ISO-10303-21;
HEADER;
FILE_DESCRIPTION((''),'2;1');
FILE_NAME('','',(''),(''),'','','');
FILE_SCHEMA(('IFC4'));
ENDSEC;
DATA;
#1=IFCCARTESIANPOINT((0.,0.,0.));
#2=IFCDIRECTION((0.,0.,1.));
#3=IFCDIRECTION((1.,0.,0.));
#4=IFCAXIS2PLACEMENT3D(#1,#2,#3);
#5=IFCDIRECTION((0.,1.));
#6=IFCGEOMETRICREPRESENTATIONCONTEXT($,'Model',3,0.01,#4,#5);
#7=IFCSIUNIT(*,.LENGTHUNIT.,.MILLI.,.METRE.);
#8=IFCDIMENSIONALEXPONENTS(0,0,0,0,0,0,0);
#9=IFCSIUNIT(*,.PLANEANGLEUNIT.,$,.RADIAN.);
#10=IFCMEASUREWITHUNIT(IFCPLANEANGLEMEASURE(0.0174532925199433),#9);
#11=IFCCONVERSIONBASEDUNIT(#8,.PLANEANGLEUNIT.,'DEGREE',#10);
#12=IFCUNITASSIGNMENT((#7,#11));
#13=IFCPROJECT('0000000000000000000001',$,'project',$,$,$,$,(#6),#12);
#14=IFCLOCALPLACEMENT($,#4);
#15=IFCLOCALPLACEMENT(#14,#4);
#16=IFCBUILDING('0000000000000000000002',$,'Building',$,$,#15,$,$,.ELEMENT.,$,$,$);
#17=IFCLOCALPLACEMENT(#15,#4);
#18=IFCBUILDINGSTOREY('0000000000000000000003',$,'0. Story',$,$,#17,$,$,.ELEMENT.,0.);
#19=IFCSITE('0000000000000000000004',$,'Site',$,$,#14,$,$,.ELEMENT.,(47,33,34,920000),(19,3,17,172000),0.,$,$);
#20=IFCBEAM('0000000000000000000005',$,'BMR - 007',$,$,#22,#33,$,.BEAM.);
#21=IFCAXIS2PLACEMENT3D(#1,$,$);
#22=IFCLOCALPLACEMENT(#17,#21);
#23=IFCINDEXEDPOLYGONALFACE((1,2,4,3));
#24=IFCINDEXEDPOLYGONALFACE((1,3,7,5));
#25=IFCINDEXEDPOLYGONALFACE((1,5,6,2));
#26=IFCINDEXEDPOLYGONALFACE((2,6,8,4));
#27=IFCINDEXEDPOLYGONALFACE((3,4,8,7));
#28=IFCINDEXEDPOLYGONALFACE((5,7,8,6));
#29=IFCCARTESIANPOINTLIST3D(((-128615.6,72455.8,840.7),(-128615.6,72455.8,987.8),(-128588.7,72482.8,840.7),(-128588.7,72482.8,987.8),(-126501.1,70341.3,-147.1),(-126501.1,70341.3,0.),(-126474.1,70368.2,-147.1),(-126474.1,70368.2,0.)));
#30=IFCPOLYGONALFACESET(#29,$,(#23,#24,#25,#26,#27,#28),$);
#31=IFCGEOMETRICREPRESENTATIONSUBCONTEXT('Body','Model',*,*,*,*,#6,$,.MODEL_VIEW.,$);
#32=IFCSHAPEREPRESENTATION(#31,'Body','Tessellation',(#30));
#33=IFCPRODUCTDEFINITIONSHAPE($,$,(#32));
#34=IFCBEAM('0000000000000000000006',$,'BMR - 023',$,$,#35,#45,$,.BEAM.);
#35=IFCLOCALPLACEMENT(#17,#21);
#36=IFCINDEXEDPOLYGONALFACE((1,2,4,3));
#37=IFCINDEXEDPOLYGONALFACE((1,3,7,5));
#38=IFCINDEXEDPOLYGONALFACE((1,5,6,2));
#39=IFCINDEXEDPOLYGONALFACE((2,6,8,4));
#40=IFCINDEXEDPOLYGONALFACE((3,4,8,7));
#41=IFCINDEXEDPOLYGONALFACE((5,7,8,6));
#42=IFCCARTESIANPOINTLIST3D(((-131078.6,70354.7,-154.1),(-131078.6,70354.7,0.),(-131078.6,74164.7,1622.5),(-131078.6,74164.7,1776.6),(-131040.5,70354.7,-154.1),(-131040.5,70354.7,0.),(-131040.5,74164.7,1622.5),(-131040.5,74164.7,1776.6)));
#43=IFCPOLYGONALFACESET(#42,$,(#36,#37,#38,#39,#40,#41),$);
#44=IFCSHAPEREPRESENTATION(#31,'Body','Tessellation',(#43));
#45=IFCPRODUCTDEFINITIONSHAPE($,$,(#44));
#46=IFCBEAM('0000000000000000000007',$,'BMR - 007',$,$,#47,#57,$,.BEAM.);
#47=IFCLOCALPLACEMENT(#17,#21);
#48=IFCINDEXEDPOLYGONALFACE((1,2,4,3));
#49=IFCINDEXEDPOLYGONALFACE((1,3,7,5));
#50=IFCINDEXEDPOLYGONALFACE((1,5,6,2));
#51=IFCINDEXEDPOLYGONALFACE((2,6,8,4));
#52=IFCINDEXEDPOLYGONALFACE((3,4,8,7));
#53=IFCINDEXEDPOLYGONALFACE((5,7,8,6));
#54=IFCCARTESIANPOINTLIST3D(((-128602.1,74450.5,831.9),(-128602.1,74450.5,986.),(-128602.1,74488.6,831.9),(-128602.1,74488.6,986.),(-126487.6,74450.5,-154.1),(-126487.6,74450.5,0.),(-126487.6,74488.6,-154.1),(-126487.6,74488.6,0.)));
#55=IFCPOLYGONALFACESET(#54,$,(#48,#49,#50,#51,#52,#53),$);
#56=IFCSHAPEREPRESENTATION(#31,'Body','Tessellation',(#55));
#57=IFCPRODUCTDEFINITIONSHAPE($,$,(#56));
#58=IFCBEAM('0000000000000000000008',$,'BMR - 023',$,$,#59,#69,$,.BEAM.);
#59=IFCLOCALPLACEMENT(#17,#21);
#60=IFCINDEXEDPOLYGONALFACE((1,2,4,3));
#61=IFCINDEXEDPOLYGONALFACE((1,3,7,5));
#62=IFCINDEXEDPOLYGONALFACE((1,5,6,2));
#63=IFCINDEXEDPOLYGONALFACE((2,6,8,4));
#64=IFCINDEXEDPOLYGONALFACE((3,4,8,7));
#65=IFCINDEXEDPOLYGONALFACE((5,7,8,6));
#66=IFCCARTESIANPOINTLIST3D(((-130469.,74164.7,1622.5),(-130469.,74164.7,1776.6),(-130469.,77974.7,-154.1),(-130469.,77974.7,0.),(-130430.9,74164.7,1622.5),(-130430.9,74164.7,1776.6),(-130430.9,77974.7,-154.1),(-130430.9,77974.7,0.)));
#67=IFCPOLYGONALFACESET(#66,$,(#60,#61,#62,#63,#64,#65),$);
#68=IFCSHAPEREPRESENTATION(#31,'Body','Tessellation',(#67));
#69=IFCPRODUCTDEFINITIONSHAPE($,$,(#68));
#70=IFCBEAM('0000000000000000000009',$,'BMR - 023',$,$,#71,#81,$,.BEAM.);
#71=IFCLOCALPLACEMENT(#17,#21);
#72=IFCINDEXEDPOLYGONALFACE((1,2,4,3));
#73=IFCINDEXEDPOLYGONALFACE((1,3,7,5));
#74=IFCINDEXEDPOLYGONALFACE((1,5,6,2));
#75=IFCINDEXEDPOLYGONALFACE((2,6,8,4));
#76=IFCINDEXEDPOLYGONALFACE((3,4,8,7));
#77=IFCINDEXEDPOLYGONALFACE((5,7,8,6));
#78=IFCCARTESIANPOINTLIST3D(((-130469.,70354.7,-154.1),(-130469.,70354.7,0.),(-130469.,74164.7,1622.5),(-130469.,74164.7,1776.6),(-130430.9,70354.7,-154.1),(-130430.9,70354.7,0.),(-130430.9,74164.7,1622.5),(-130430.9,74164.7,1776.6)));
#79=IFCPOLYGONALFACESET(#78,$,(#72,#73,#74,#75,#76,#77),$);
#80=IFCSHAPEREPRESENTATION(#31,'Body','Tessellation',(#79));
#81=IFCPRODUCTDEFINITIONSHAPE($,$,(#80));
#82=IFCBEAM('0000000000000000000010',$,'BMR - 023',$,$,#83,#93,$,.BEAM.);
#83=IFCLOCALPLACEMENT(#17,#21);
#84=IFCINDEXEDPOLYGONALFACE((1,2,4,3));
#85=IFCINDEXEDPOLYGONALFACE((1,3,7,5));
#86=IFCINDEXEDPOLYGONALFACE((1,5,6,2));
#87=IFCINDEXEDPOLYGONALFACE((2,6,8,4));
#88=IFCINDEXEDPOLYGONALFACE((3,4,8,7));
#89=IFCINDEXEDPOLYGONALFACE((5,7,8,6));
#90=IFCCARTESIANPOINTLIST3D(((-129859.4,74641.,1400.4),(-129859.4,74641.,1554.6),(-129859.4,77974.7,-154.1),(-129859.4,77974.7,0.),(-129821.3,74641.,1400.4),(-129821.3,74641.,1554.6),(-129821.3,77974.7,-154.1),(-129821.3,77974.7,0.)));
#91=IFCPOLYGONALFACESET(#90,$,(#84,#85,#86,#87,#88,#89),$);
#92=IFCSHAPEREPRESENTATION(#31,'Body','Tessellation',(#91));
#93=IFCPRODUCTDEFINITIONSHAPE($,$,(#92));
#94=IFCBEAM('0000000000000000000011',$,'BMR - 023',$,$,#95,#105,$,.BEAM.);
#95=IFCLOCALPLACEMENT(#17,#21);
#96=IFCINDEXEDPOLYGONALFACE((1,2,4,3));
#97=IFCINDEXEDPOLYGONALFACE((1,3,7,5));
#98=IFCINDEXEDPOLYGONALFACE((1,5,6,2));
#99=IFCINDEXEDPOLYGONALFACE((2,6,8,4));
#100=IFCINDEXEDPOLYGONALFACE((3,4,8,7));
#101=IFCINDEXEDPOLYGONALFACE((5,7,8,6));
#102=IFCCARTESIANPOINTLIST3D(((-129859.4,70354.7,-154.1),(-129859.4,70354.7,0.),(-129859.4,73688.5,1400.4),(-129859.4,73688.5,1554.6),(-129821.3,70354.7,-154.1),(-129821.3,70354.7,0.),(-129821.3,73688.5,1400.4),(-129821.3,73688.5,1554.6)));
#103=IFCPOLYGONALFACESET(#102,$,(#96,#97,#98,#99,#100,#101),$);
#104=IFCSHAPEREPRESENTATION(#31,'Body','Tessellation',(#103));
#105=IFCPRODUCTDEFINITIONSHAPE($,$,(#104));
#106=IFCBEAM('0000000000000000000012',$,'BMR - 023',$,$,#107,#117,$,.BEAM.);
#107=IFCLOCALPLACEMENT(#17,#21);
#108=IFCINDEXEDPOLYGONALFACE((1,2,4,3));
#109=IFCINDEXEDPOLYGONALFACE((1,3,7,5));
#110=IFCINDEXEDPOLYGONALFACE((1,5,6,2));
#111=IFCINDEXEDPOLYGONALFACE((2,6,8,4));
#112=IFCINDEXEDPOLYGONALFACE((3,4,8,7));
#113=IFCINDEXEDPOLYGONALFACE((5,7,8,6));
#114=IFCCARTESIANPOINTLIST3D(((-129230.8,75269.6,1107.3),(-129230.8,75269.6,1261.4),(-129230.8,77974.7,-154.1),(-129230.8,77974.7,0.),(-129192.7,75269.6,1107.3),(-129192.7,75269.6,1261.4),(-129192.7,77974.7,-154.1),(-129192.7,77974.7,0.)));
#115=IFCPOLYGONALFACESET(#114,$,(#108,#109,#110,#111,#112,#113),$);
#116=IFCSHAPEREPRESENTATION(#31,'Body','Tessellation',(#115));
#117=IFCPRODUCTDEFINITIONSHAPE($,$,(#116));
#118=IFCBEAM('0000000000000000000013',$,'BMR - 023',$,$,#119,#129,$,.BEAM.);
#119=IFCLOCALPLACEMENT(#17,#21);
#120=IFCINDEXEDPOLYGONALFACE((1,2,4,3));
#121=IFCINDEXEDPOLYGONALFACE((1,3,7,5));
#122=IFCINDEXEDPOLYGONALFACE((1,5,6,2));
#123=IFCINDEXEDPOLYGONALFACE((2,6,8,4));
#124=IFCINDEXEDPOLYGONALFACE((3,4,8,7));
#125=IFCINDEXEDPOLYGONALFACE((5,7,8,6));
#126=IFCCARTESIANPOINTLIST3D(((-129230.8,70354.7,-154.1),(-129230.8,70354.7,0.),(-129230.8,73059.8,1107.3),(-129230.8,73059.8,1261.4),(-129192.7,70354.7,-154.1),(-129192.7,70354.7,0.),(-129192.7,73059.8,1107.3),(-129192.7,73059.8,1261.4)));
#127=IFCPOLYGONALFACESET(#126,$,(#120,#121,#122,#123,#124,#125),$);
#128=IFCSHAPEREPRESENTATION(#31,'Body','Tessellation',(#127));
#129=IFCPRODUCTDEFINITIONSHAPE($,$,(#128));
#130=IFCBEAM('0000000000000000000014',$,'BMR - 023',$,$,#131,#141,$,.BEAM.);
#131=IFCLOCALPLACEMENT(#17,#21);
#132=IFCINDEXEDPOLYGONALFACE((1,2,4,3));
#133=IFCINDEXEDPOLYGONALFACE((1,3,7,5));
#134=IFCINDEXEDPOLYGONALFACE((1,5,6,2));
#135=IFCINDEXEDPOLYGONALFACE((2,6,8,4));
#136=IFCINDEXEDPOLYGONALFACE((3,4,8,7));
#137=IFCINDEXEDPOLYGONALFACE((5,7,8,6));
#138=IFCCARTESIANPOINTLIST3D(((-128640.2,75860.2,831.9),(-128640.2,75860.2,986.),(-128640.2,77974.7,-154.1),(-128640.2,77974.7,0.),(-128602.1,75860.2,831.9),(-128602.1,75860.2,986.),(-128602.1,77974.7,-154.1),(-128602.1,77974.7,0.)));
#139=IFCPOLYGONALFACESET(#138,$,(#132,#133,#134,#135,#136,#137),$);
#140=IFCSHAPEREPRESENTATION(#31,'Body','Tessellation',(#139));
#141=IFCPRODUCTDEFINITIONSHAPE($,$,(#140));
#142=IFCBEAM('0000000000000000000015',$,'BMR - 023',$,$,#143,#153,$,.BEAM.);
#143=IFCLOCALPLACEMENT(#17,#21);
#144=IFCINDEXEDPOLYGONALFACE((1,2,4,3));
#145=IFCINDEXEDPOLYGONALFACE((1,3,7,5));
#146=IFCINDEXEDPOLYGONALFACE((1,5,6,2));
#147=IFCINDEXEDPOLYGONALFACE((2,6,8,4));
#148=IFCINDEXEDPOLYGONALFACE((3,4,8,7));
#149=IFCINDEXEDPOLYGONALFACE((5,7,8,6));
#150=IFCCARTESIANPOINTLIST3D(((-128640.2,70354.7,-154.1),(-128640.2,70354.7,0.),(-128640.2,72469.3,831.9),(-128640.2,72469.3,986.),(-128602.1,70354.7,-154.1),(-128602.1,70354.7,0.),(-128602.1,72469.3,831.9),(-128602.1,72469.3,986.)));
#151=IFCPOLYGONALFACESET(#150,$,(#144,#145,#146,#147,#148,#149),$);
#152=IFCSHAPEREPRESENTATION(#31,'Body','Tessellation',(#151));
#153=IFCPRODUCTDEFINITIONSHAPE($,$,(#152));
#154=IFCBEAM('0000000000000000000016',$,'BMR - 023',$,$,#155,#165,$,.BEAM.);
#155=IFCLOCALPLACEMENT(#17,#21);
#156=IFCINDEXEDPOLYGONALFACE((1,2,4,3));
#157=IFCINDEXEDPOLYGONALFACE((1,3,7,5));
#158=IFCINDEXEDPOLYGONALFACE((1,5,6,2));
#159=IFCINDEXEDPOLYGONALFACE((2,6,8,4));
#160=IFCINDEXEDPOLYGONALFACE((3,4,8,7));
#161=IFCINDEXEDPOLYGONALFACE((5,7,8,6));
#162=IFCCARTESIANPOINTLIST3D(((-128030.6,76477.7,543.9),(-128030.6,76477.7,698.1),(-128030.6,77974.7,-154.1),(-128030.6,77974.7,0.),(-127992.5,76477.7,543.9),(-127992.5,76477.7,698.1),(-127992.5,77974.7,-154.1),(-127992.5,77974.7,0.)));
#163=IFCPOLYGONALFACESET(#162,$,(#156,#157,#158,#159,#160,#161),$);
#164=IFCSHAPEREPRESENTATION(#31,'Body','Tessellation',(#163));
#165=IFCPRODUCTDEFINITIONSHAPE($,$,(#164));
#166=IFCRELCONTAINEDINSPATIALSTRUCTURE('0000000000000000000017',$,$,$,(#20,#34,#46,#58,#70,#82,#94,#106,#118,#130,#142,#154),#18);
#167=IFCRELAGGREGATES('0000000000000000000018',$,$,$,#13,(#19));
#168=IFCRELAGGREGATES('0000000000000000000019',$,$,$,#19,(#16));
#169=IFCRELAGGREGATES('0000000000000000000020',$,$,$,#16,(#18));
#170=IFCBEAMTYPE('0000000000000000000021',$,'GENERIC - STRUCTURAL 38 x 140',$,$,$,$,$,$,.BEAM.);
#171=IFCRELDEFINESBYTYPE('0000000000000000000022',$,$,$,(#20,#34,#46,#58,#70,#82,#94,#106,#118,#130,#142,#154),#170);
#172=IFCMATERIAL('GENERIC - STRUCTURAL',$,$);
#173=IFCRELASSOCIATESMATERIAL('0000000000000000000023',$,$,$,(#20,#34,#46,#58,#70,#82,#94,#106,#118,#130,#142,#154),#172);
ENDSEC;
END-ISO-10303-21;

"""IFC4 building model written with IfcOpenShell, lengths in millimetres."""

from ifc_helpers import new_model, entity, si_unit, converted_unit, direction, frame, frame_2d, origin_with_axes, place, context, subcontext, project, spatial, rectangle, extrude, clip, halfspace, material, type_object, element, save


model = new_model("IFC4")

# Units and contexts
model_context = context("Model", 3, precision=0.01, world=origin_with_axes(), true_north=direction((0.0, 1.0)))
body_context = subcontext(model_context, "Body", "Model", "MODEL_VIEW")
ifc_project = project(units=[si_unit("LENGTHUNIT", "METRE", prefix="MILLI"), converted_unit("PLANEANGLEUNIT", "DEGREE", entity("IfcPlaneAngleMeasure", 0.0174532925199433), si_unit("PLANEANGLEUNIT", "RADIAN"), dimensions=[0, 0, 0, 0, 0, 0, 0])], contexts=[model_context])

# Site, building, storey
site_placement = place(None, origin_with_axes())
site = spatial("IfcSite", under=ifc_project, at=site_placement, Name="Site", CompositionType="ELEMENT", RefLatitude=(47, 33, 34, 920000), RefLongitude=(19, 3, 17, 172000), RefElevation=0.0)
building_placement = place(site_placement, origin_with_axes())
building = spatial("IfcBuilding", under=site, at=building_placement, Name="Building", CompositionType="ELEMENT")
storey_placement = place(building_placement, origin_with_axes())
storey = spatial("IfcBuildingStorey", under=building, at=storey_placement, Name="0. Story", CompositionType="ELEMENT", Elevation=0.0)

# Beams
ifc_material = material(Name="GENERIC - STRUCTURAL")
beam_type = type_object("IfcBeamType", Name="GENERIC - STRUCTURAL 38 x 140", PredefinedType="BEAM")
beam_1_placement = place(storey_placement, frame((-126487.6, 70354.7, 0.0), z_axis=(0.0, 0.0, 1.0), x_axis=(0.707107, 0.707107, 0.0)))
element("IfcBeam", 1, at=beam_1_placement, inside=storey, type_object=beam_type, material=ifc_material, Name="BMR - 007", PredefinedType="BEAM", context=body_context, shape_type="Clipping", body=[
    clip(clip(extrude(rectangle(XDim=139.7, YDim=38.1, at=frame_2d((-69.8, 0.0), x_axis=(1.0, 0.0))), frame((0.0, -62.0, -20.5), z_axis=(0.0, 0.94954, 0.313647), x_axis=(0.0, -0.313647, 0.94954)), (0.0, 0.0, 1.0), 3279.9), halfspace(frame((0.0, 0.0, 0.0), z_axis=(0.0, 1.0, 0.0), x_axis=(0.0, 0.0, 1.0)), True)), halfspace(frame((0.0, 2990.4, 0.0), z_axis=(0.0, -1.0, 0.0), x_axis=(0.0, 0.0, -1.0)), True)),
])
beam_2_placement = place(storey_placement, frame((-131059.6, 70354.7, 0.0), z_axis=(0.0, 0.0, 1.0), x_axis=(1.0, 0.0, 0.0)))
element("IfcBeam", 2, at=beam_2_placement, inside=storey, type_object=beam_type, material=ifc_material, Name="BMR - 023", PredefinedType="BEAM", context=body_context, shape_type="Clipping", body=[
    clip(clip(extrude(rectangle(XDim=139.7, YDim=38.1, at=frame_2d((-69.8, 0.0), x_axis=(1.0, 0.0))), frame((0.0, -83.5, -38.9), z_axis=(0.0, 0.906308, 0.422618), x_axis=(0.0, -0.422618, 0.906308)), (0.0, 0.0, 1.0), 4388.1), halfspace(frame((0.0, 0.0, 0.0), z_axis=(0.0, 1.0, 0.0), x_axis=(0.0, 0.0, 1.0)), True)), halfspace(frame((0.0, 3810.0, 0.0), z_axis=(0.0, -1.0, 0.0), x_axis=(0.0, 0.0, -1.0)), True)),
])
beam_3_placement = place(storey_placement, frame((-126487.6, 74469.5, 0.0), z_axis=(0.0, 0.0, 1.0), x_axis=(0.0, 1.0, 0.0)))
element("IfcBeam", 3, at=beam_3_placement, inside=storey, type_object=beam_type, material=ifc_material, Name="BMR - 007", PredefinedType="BEAM", context=body_context, shape_type="Clipping", body=[
    clip(clip(extrude(rectangle(XDim=139.7, YDim=38.1, at=frame_2d((-69.8, 0.0), x_axis=(1.0, 0.0))), frame((0.0, -83.5, -38.9), z_axis=(0.0, 0.906308, 0.422618), x_axis=(0.0, -0.422618, 0.906308)), (0.0, 0.0, 1.0), 2517.4), halfspace(frame((0.0, 0.0, 0.0), z_axis=(0.0, 1.0, 0.0), x_axis=(0.0, 0.0, 1.0)), True)), halfspace(frame((0.0, 2114.5, 0.0), z_axis=(0.0, -1.0, 0.0), x_axis=(0.0, 0.0, -1.0)), True)),
])
beam_4_placement = place(storey_placement, frame((-130450.0, 77974.7, 0.0), z_axis=(0.0, 0.0, 1.0), x_axis=(-1.0, 0.0, 0.0)))
element("IfcBeam", 4, at=beam_4_placement, inside=storey, type_object=beam_type, material=ifc_material, Name="BMR - 023", PredefinedType="BEAM", context=body_context, shape_type="Clipping", body=[
    clip(clip(extrude(rectangle(XDim=139.7, YDim=38.1, at=frame_2d((-69.8, 0.0), x_axis=(1.0, 0.0))), frame((0.0, -83.5, -38.9), z_axis=(0.0, 0.906308, 0.422618), x_axis=(0.0, -0.422618, 0.906308)), (0.0, 0.0, 1.0), 4388.1), halfspace(frame((0.0, 0.0, 0.0), z_axis=(0.0, 1.0, 0.0), x_axis=(0.0, 0.0, 1.0)), True)), halfspace(frame((0.0, 3810.0, 0.0), z_axis=(0.0, -1.0, 0.0), x_axis=(0.0, 0.0, -1.0)), True)),
])
beam_5_placement = place(storey_placement, frame((-130450.0, 70354.7, 0.0), z_axis=(0.0, 0.0, 1.0), x_axis=(1.0, 0.0, 0.0)))
element("IfcBeam", 5, at=beam_5_placement, inside=storey, type_object=beam_type, material=ifc_material, Name="BMR - 023", PredefinedType="BEAM", context=body_context, shape_type="Clipping", body=[
    clip(clip(extrude(rectangle(XDim=139.7, YDim=38.1, at=frame_2d((-69.8, 0.0), x_axis=(1.0, 0.0))), frame((0.0, -83.5, -38.9), z_axis=(0.0, 0.906308, 0.422618), x_axis=(0.0, -0.422618, 0.906308)), (0.0, 0.0, 1.0), 4388.1), halfspace(frame((0.0, 0.0, 0.0), z_axis=(0.0, 1.0, 0.0), x_axis=(0.0, 0.0, 1.0)), True)), halfspace(frame((0.0, 3810.0, 0.0), z_axis=(0.0, -1.0, 0.0), x_axis=(0.0, 0.0, -1.0)), True)),
])
beam_6_placement = place(storey_placement, frame((-129840.4, 77974.7, 0.0), z_axis=(0.0, 0.0, 1.0), x_axis=(-1.0, 0.0, 0.0)))
element("IfcBeam", 6, at=beam_6_placement, inside=storey, type_object=beam_type, material=ifc_material, Name="BMR - 023", PredefinedType="BEAM", context=body_context, shape_type="Clipping", body=[
    clip(clip(extrude(rectangle(XDim=139.7, YDim=38.1, at=frame_2d((-69.8, 0.0), x_axis=(1.0, 0.0))), frame((0.0, -83.5, -38.9), z_axis=(0.0, 0.906308, 0.422618), x_axis=(0.0, -0.422618, 0.906308)), (0.0, 0.0, 1.0), 3862.6), halfspace(frame((0.0, 0.0, 0.0), z_axis=(0.0, 1.0, 0.0), x_axis=(0.0, 0.0, 1.0)), True)), halfspace(frame((0.0, 3333.8, 0.0), z_axis=(0.0, -1.0, 0.0), x_axis=(0.0, 0.0, -1.0)), True)),
])
beam_7_placement = place(storey_placement, frame((-129840.4, 70354.7, 0.0), z_axis=(0.0, 0.0, 1.0), x_axis=(1.0, 0.0, 0.0)))
element("IfcBeam", 7, at=beam_7_placement, inside=storey, type_object=beam_type, material=ifc_material, Name="BMR - 023", PredefinedType="BEAM", context=body_context, shape_type="Clipping", body=[
    clip(clip(extrude(rectangle(XDim=139.7, YDim=38.1, at=frame_2d((-69.8, 0.0), x_axis=(1.0, 0.0))), frame((0.0, -83.5, -38.9), z_axis=(0.0, 0.906308, 0.422618), x_axis=(0.0, -0.422618, 0.906308)), (0.0, 0.0, 1.0), 3862.6), halfspace(frame((0.0, 0.0, 0.0), z_axis=(0.0, 1.0, 0.0), x_axis=(0.0, 0.0, 1.0)), True)), halfspace(frame((0.0, 3333.7, 0.0), z_axis=(0.0, -1.0, 0.0), x_axis=(0.0, 0.0, -1.0)), True)),
])
beam_8_placement = place(storey_placement, frame((-129211.7, 77974.7, 0.0), z_axis=(0.0, 0.0, 1.0), x_axis=(-1.0, 0.0, 0.0)))
element("IfcBeam", 8, at=beam_8_placement, inside=storey, type_object=beam_type, material=ifc_material, Name="BMR - 023", PredefinedType="BEAM", context=body_context, shape_type="Clipping", body=[
    clip(clip(extrude(rectangle(XDim=139.7, YDim=38.1, at=frame_2d((-69.8, 0.0), x_axis=(1.0, 0.0))), frame((0.0, -83.5, -38.9), z_axis=(0.0, 0.906308, 0.422618), x_axis=(0.0, -0.422618, 0.906308)), (0.0, 0.0, 1.0), 3169.0), halfspace(frame((0.0, 0.0, 0.0), z_axis=(0.0, 1.0, 0.0), x_axis=(0.0, 0.0, 1.0)), True)), halfspace(frame((0.0, 2705.1, 0.0), z_axis=(0.0, -1.0, 0.0), x_axis=(0.0, 0.0, -1.0)), True)),
])
beam_9_placement = place(storey_placement, frame((-129211.7, 70354.7, 0.0), z_axis=(0.0, 0.0, 1.0), x_axis=(1.0, 0.0, 0.0)))
element("IfcBeam", 9, at=beam_9_placement, inside=storey, type_object=beam_type, material=ifc_material, Name="BMR - 023", PredefinedType="BEAM", context=body_context, shape_type="Clipping", body=[
    clip(clip(extrude(rectangle(XDim=139.7, YDim=38.1, at=frame_2d((-69.8, 0.0), x_axis=(1.0, 0.0))), frame((0.0, -83.5, -38.9), z_axis=(0.0, 0.906308, 0.422618), x_axis=(0.0, -0.422618, 0.906308)), (0.0, 0.0, 1.0), 3169.0), halfspace(frame((0.0, 0.0, 0.0), z_axis=(0.0, 1.0, 0.0), x_axis=(0.0, 0.0, 1.0)), True)), halfspace(frame((0.0, 2705.1, 0.0), z_axis=(0.0, -1.0, 0.0), x_axis=(0.0, 0.0, -1.0)), True)),
])
beam_10_placement = place(storey_placement, frame((-128621.2, 77974.7, 0.0), z_axis=(0.0, 0.0, 1.0), x_axis=(-1.0, 0.0, 0.0)))
element("IfcBeam", 10, at=beam_10_placement, inside=storey, type_object=beam_type, material=ifc_material, Name="BMR - 023", PredefinedType="BEAM", context=body_context, shape_type="Clipping", body=[
    clip(clip(extrude(rectangle(XDim=139.7, YDim=38.1, at=frame_2d((-69.8, 0.0), x_axis=(1.0, 0.0))), frame((0.0, -83.5, -38.9), z_axis=(0.0, 0.906308, 0.422618), x_axis=(0.0, -0.422618, 0.906308)), (0.0, 0.0, 1.0), 2517.4), halfspace(frame((0.0, 0.0, 0.0), z_axis=(0.0, 1.0, 0.0), x_axis=(0.0, 0.0, 1.0)), True)), halfspace(frame((0.0, 2114.6, 0.0), z_axis=(0.0, -1.0, 0.0), x_axis=(0.0, 0.0, -1.0)), True)),
])
beam_11_placement = place(storey_placement, frame((-128621.2, 70354.7, 0.0), z_axis=(0.0, 0.0, 1.0), x_axis=(1.0, 0.0, 0.0)))
element("IfcBeam", 11, at=beam_11_placement, inside=storey, type_object=beam_type, material=ifc_material, Name="BMR - 023", PredefinedType="BEAM", context=body_context, shape_type="Clipping", body=[
    clip(clip(extrude(rectangle(XDim=139.7, YDim=38.1, at=frame_2d((-69.8, 0.0), x_axis=(1.0, 0.0))), frame((0.0, -83.5, -38.9), z_axis=(0.0, 0.906308, 0.422618), x_axis=(0.0, -0.422618, 0.906308)), (0.0, 0.0, 1.0), 2517.4), halfspace(frame((0.0, 0.0, 0.0), z_axis=(0.0, 1.0, 0.0), x_axis=(0.0, 0.0, 1.0)), True)), halfspace(frame((0.0, 2114.5, 0.0), z_axis=(0.0, -1.0, 0.0), x_axis=(0.0, 0.0, -1.0)), True)),
])
beam_12_placement = place(storey_placement, frame((-128011.6, 77974.7, 0.0), z_axis=(0.0, 0.0, 1.0), x_axis=(-1.0, 0.0, 0.0)))
element("IfcBeam", 12, at=beam_12_placement, inside=storey, type_object=beam_type, material=ifc_material, Name="BMR - 023", PredefinedType="BEAM", context=body_context, shape_type="Clipping", body=[
    clip(clip(extrude(rectangle(XDim=139.7, YDim=38.1, at=frame_2d((-69.8, 0.0), x_axis=(1.0, 0.0))), frame((0.0, -83.5, -38.9), z_axis=(0.0, 0.906308, 0.422618), x_axis=(0.0, -0.422618, 0.906308)), (0.0, 0.0, 1.0), 1836.1), halfspace(frame((0.0, 0.0, 0.0), z_axis=(0.0, 1.0, 0.0), x_axis=(0.0, 0.0, 1.0)), True)), halfspace(frame((0.0, 1497.1, 0.0), z_axis=(0.0, -1.0, 0.0), x_axis=(0.0, 0.0, -1.0)), True)),
])

save(model, "model.ifc")
